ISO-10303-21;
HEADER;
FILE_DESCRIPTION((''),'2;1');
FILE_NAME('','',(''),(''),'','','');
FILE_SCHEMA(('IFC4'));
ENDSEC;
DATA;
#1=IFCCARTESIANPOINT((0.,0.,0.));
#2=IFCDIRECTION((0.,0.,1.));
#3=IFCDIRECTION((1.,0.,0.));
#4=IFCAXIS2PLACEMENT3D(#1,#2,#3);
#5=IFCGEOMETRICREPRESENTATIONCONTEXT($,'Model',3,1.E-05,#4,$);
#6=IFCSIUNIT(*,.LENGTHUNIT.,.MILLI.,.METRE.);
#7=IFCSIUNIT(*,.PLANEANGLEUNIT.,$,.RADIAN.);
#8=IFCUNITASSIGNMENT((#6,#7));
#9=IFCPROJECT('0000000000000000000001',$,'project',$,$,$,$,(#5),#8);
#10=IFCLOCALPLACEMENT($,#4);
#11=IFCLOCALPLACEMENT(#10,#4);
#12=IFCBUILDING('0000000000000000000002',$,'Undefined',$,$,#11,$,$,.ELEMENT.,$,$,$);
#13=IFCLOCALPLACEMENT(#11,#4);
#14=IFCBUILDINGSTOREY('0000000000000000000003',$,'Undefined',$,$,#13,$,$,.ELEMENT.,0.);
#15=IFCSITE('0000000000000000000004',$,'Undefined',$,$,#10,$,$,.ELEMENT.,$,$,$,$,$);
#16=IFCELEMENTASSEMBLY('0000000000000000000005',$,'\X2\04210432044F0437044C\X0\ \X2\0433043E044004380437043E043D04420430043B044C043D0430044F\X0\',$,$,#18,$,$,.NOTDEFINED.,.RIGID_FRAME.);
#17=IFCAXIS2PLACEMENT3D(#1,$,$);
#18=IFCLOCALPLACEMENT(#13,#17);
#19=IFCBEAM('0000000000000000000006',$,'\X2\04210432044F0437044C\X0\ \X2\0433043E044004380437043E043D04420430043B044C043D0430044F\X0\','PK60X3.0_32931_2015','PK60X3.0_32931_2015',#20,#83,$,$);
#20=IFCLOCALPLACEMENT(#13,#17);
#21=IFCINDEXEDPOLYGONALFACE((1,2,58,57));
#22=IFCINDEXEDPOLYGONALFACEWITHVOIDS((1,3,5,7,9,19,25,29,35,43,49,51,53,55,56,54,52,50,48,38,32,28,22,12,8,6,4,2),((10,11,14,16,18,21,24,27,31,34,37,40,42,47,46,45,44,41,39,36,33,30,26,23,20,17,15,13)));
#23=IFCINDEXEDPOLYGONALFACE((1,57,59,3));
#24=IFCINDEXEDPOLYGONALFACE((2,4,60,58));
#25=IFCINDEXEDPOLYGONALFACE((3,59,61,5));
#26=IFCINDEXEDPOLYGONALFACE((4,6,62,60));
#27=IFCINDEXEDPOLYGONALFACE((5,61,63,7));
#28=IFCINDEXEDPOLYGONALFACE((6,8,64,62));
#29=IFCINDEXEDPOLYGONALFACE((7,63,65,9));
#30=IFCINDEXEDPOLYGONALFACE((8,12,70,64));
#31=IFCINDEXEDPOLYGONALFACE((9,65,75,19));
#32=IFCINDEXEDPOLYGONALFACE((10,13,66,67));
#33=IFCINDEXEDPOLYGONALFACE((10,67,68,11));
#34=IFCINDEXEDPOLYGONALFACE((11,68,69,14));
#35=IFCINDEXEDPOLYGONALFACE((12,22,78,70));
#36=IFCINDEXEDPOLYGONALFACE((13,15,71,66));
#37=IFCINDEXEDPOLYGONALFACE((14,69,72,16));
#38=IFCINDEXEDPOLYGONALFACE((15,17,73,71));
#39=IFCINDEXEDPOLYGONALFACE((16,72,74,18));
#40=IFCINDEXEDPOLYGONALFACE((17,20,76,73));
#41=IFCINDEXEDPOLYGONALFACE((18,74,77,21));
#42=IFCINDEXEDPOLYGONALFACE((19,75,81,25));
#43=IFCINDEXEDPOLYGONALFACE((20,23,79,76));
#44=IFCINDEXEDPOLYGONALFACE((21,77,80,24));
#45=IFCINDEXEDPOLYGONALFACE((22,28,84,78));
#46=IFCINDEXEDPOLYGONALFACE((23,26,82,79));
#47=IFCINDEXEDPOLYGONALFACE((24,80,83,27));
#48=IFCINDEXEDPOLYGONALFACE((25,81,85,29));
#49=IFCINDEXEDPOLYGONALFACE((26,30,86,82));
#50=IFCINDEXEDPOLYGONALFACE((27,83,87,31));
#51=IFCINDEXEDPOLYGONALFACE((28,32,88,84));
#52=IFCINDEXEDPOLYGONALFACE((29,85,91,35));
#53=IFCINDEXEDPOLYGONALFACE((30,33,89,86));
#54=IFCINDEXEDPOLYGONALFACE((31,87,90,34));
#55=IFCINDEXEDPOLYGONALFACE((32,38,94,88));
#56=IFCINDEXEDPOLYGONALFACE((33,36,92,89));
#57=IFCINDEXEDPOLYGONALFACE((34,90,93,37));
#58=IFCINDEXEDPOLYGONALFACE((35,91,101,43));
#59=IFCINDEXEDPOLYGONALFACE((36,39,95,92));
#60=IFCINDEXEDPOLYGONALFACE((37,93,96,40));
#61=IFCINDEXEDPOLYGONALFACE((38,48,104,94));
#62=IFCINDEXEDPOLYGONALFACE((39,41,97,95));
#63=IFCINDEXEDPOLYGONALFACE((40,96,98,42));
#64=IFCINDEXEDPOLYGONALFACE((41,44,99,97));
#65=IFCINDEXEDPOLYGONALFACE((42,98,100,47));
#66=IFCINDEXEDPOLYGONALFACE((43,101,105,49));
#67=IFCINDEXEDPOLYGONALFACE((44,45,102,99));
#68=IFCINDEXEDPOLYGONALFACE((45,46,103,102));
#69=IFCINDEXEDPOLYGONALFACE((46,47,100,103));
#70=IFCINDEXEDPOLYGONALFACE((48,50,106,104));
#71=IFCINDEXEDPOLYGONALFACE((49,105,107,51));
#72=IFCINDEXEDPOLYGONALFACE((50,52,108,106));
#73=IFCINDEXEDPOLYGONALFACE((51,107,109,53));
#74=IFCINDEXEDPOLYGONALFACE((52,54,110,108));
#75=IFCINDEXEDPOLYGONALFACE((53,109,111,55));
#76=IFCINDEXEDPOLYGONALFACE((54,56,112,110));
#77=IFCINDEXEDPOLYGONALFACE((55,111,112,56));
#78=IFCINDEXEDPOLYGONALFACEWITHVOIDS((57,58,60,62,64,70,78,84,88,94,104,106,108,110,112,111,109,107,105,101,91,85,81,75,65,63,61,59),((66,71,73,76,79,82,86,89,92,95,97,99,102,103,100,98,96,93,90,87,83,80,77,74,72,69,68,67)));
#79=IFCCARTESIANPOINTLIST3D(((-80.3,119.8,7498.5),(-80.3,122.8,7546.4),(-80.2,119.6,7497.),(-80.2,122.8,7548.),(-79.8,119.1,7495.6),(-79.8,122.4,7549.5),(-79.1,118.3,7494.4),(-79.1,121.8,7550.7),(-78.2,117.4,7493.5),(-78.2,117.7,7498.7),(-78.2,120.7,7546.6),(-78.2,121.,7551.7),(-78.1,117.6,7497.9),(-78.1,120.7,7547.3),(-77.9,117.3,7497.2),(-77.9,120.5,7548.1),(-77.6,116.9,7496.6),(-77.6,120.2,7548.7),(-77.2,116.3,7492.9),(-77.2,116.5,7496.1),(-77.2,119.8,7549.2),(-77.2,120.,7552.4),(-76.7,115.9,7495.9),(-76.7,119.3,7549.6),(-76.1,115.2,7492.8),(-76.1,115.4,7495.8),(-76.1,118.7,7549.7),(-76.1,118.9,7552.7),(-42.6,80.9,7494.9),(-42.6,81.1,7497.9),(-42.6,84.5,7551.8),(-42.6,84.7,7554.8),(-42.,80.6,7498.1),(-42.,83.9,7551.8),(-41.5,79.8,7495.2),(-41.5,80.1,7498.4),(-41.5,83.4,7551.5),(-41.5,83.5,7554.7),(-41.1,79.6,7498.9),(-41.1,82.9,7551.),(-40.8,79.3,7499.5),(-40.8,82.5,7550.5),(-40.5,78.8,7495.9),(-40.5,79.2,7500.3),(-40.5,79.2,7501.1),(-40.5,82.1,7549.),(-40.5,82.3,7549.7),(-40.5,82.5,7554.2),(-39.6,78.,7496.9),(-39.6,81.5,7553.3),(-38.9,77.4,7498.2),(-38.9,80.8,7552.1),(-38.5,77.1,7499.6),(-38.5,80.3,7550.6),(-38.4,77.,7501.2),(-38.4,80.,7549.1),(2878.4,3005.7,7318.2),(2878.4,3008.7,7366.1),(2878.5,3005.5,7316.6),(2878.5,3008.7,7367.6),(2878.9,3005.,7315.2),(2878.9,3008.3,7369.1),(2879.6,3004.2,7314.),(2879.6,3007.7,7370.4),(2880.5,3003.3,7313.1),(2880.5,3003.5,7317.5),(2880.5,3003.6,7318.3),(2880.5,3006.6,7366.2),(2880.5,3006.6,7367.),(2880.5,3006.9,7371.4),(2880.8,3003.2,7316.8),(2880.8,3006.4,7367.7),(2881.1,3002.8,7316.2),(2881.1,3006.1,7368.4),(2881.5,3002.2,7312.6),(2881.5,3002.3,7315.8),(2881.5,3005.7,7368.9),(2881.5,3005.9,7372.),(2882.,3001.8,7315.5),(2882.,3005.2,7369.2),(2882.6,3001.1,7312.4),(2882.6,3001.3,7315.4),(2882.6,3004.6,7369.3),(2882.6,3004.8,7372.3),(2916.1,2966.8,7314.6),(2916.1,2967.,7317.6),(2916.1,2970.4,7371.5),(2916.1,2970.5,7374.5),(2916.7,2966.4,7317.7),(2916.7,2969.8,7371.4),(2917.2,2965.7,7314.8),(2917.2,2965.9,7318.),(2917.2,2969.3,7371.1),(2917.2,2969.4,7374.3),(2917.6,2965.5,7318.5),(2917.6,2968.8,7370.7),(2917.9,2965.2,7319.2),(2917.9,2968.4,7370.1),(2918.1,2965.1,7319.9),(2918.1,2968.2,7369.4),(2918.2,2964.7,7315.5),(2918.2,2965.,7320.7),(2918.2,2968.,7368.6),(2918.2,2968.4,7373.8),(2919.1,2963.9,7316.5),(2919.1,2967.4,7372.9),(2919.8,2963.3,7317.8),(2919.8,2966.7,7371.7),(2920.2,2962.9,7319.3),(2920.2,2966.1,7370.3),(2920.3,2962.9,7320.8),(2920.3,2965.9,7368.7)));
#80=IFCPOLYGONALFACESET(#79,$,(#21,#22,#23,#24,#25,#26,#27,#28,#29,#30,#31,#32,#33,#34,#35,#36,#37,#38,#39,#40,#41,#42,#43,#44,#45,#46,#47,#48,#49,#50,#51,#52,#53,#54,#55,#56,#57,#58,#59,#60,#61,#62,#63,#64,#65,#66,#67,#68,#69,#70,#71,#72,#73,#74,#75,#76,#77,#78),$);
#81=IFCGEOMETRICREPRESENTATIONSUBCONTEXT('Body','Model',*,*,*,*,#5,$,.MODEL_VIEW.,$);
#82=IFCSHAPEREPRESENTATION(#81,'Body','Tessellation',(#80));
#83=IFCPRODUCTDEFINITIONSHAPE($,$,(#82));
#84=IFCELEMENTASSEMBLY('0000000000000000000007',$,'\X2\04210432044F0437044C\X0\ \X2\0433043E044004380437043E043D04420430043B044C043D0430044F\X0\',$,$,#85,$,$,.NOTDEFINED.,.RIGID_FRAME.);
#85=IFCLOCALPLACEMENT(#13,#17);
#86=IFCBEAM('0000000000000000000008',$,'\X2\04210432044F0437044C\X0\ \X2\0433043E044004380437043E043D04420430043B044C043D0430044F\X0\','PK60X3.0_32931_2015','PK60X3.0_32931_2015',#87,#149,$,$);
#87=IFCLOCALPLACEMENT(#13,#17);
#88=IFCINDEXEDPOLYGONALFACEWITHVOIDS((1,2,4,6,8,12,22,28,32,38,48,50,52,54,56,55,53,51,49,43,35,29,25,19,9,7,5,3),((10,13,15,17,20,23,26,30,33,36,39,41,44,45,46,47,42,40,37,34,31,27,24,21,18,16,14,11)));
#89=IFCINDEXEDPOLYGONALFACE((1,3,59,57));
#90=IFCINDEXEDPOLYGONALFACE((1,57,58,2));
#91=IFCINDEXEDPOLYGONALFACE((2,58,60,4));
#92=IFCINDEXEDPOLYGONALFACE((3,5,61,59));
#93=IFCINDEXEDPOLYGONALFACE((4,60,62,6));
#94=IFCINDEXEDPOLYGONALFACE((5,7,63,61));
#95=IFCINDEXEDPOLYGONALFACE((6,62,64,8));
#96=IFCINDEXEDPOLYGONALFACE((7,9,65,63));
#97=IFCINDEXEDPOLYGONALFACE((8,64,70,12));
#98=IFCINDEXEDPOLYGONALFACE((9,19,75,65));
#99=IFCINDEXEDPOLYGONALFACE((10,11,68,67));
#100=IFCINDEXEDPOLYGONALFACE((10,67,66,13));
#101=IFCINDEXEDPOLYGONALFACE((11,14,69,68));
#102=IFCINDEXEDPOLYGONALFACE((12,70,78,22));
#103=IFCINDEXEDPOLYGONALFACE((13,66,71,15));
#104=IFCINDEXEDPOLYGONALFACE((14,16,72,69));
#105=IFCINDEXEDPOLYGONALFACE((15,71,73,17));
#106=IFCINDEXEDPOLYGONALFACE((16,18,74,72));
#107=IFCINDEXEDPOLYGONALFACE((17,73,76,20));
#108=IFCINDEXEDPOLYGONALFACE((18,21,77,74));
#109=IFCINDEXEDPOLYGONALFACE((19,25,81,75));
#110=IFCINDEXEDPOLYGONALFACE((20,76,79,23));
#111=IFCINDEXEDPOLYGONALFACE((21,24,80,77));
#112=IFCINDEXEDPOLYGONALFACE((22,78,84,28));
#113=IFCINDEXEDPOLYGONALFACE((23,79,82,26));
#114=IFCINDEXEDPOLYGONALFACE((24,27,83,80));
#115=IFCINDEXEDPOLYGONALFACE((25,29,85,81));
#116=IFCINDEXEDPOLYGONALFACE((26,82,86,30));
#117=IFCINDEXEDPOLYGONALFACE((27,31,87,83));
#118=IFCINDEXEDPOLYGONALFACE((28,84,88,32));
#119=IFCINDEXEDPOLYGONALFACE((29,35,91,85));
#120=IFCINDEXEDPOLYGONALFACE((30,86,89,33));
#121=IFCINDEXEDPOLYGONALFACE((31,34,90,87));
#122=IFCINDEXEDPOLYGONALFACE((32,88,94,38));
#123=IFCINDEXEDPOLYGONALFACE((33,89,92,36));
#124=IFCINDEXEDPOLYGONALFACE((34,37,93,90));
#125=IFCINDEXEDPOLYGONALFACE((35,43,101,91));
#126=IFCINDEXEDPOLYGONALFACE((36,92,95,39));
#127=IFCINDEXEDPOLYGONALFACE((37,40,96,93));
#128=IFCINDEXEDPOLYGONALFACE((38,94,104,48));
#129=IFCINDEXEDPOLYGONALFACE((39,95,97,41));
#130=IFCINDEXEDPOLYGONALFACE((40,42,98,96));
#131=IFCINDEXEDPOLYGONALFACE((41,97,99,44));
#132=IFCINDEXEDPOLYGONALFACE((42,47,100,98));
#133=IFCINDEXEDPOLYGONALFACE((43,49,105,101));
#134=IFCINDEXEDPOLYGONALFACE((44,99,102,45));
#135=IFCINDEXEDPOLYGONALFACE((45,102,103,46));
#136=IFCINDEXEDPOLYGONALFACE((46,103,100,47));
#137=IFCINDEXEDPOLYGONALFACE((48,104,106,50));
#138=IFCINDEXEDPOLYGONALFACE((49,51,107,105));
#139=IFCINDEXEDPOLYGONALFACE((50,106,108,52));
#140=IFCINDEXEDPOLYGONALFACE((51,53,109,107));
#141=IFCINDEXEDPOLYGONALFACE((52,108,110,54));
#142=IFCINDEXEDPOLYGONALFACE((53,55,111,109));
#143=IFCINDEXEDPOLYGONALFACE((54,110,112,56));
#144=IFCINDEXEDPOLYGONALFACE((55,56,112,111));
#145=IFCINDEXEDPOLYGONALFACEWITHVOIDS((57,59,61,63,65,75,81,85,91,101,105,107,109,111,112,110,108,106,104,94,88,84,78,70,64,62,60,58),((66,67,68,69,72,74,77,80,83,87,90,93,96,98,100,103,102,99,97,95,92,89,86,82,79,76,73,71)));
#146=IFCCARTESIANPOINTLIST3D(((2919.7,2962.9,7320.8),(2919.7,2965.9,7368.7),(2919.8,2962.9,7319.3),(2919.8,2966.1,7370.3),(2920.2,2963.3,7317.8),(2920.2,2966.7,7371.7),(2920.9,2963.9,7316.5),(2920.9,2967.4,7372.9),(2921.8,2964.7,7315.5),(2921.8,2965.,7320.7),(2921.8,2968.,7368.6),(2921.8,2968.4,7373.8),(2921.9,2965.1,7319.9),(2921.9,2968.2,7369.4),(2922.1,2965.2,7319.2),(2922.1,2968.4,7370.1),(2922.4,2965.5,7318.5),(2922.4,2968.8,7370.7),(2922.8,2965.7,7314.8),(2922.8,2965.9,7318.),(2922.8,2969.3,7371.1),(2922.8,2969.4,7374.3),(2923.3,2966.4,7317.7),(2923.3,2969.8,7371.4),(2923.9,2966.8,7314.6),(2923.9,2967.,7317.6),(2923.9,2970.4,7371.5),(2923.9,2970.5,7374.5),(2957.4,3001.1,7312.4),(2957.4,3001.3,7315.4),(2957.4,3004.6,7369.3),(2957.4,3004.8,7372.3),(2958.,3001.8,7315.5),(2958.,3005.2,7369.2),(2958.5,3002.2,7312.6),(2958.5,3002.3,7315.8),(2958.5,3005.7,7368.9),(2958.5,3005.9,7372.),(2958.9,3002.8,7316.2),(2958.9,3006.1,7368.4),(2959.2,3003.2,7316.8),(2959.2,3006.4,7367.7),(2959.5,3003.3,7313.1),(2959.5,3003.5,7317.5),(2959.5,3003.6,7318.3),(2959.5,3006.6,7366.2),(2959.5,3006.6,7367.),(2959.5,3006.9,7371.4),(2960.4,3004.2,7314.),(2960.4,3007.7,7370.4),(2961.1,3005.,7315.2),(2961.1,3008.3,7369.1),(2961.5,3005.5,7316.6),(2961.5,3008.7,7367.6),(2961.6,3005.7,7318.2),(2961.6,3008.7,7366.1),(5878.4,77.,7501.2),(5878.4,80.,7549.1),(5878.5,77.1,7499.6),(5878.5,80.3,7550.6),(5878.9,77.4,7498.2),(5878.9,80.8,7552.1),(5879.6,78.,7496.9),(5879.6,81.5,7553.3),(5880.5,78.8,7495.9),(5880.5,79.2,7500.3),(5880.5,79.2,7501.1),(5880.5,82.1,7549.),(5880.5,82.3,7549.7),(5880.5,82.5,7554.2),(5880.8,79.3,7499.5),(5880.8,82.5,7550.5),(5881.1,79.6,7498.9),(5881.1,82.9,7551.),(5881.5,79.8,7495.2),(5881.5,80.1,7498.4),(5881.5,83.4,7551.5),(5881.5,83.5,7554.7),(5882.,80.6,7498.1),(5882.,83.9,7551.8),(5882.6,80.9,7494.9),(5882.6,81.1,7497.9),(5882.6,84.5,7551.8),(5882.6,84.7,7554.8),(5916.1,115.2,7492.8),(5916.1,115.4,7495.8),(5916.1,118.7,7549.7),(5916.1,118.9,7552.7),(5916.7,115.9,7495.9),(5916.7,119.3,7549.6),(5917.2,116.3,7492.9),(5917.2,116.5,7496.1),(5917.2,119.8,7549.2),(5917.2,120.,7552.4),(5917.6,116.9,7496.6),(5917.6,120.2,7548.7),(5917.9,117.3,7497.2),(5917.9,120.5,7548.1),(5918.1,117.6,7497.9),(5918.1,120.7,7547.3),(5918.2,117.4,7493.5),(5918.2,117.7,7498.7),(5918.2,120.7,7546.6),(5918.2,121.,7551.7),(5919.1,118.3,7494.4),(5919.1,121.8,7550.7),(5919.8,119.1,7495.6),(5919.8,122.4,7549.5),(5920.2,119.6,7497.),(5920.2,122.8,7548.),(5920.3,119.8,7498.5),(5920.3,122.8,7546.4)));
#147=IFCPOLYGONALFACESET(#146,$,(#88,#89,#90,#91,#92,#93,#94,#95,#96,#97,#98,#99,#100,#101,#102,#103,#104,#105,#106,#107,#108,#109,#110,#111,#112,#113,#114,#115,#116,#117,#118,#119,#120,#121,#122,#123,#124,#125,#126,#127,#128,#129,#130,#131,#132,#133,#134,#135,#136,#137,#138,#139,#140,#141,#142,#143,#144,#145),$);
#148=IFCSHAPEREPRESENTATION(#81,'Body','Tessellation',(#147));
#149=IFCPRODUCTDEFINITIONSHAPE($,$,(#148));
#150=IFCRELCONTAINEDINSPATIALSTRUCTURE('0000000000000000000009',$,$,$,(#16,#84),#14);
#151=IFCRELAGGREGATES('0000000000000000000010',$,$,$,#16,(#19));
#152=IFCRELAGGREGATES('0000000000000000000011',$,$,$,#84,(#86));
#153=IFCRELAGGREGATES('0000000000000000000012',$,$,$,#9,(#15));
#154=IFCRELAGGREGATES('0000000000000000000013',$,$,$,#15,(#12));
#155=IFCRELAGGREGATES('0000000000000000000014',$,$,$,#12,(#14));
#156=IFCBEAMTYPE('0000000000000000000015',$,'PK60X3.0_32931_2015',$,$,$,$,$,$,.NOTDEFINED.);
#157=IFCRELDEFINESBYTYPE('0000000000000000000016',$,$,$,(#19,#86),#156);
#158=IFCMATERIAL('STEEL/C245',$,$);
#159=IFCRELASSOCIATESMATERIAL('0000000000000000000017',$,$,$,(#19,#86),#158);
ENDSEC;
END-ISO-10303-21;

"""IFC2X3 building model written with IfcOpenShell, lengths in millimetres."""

from ifc_helpers import new_model, si_unit, frame, origin_with_axes, origin_2d_with_axis, place, context, subcontext, project, spatial, hollow_rectangle, extrude, material, type_object, element, aggregate, save


model = new_model("IFC2X3")

# Units and contexts
model_context = context("Model", 3, precision=1e-05, world=origin_with_axes())
body_context = subcontext(model_context, "Body", "Model", "MODEL_VIEW")
ifc_project = project(units=[si_unit("LENGTHUNIT", "METRE", prefix="MILLI"), si_unit("PLANEANGLEUNIT", "RADIAN")], contexts=[model_context])

# Site, building, storey
site_placement = place(None, origin_with_axes())
site = spatial("IfcSite", under=ifc_project, at=site_placement, Name="Undefined", CompositionType="ELEMENT")
building_placement = place(site_placement, origin_with_axes())
building = spatial("IfcBuilding", under=site, at=building_placement, Name="Undefined", CompositionType="ELEMENT")
storey_placement = place(building_placement, origin_with_axes())
storey = spatial("IfcBuildingStorey", under=building, at=storey_placement, Name="Undefined", CompositionType="ELEMENT", Elevation=0.0)

# Shared definitions
ifc_material = material(Name="STEEL/C245")

# Element assemblies, beams
beam_type_1 = type_object("IfcBeamType", Name="PK60X3.0_32931_2015", PredefinedType="NOTDEFINED")
assembly_1_placement = place(storey_placement, origin_with_axes())
assembly_1 = element("IfcElementAssembly", 1, at=assembly_1_placement, inside=storey, Name="Связь горизонтальная", AssemblyPlace="NOTDEFINED", PredefinedType="RIGID_FRAME")
beam_1_placement = place(assembly_1_placement, frame((-59.3, 99.9, 7523.8), z_axis=(0.0, 0.062378, 0.998053), x_axis=(0.715179, 0.69758, -0.043599)))
beam_1 = element("IfcBeam", 2, at=beam_1_placement, type_object=beam_type_1, material=ifc_material, Name="Связь горизонтальная", Description="PK60X3.0_32931_2015", ObjectType="PK60X3.0_32931_2015", context=body_context, shape_type="SweptSolid", body=[
    extrude(hollow_rectangle(XDim=60.0, YDim=60.0, WallThickness=3.0, InnerFilletRadius=3.0, OuterFilletRadius=6.0, at=origin_2d_with_axis()), frame((4137.0, 0.0, 0.0), z_axis=(-1.0, 0.0, 0.0), x_axis=(0.0, -1.0, 0.0)), (0.0, 0.0, 1.0), 4137.0),
])
aggregate(assembly_1, [beam_1])
assembly_2_placement = place(storey_placement, origin_with_axes())
assembly_2 = element("IfcElementAssembly", 3, at=assembly_2_placement, inside=storey, Name="Связь горизонтальная", AssemblyPlace="NOTDEFINED", PredefinedType="RIGID_FRAME")
beam_2_placement = place(assembly_2_placement, frame((5899.3, 99.9, 7523.8), z_axis=(0.0, 0.062378, 0.998053), x_axis=(-0.715179, 0.69758, -0.043599)))
beam_2 = element("IfcBeam", 4, at=beam_2_placement, type_object=beam_type_1, material=ifc_material, Name="Связь горизонтальная", Description="PK60X3.0_32931_2015", ObjectType="PK60X3.0_32931_2015", context=body_context, shape_type="SweptSolid", body=[
    extrude(hollow_rectangle(XDim=60.0, YDim=60.0, WallThickness=3.0, InnerFilletRadius=3.0, OuterFilletRadius=6.0, at=origin_2d_with_axis()), frame((4137.0, 0.0, 0.0), z_axis=(-1.0, 0.0, 0.0), x_axis=(0.0, -1.0, 0.0)), (0.0, 0.0, 1.0), 4137.0),
])
aggregate(assembly_2, [beam_2])

save(model, "model.ifc")
